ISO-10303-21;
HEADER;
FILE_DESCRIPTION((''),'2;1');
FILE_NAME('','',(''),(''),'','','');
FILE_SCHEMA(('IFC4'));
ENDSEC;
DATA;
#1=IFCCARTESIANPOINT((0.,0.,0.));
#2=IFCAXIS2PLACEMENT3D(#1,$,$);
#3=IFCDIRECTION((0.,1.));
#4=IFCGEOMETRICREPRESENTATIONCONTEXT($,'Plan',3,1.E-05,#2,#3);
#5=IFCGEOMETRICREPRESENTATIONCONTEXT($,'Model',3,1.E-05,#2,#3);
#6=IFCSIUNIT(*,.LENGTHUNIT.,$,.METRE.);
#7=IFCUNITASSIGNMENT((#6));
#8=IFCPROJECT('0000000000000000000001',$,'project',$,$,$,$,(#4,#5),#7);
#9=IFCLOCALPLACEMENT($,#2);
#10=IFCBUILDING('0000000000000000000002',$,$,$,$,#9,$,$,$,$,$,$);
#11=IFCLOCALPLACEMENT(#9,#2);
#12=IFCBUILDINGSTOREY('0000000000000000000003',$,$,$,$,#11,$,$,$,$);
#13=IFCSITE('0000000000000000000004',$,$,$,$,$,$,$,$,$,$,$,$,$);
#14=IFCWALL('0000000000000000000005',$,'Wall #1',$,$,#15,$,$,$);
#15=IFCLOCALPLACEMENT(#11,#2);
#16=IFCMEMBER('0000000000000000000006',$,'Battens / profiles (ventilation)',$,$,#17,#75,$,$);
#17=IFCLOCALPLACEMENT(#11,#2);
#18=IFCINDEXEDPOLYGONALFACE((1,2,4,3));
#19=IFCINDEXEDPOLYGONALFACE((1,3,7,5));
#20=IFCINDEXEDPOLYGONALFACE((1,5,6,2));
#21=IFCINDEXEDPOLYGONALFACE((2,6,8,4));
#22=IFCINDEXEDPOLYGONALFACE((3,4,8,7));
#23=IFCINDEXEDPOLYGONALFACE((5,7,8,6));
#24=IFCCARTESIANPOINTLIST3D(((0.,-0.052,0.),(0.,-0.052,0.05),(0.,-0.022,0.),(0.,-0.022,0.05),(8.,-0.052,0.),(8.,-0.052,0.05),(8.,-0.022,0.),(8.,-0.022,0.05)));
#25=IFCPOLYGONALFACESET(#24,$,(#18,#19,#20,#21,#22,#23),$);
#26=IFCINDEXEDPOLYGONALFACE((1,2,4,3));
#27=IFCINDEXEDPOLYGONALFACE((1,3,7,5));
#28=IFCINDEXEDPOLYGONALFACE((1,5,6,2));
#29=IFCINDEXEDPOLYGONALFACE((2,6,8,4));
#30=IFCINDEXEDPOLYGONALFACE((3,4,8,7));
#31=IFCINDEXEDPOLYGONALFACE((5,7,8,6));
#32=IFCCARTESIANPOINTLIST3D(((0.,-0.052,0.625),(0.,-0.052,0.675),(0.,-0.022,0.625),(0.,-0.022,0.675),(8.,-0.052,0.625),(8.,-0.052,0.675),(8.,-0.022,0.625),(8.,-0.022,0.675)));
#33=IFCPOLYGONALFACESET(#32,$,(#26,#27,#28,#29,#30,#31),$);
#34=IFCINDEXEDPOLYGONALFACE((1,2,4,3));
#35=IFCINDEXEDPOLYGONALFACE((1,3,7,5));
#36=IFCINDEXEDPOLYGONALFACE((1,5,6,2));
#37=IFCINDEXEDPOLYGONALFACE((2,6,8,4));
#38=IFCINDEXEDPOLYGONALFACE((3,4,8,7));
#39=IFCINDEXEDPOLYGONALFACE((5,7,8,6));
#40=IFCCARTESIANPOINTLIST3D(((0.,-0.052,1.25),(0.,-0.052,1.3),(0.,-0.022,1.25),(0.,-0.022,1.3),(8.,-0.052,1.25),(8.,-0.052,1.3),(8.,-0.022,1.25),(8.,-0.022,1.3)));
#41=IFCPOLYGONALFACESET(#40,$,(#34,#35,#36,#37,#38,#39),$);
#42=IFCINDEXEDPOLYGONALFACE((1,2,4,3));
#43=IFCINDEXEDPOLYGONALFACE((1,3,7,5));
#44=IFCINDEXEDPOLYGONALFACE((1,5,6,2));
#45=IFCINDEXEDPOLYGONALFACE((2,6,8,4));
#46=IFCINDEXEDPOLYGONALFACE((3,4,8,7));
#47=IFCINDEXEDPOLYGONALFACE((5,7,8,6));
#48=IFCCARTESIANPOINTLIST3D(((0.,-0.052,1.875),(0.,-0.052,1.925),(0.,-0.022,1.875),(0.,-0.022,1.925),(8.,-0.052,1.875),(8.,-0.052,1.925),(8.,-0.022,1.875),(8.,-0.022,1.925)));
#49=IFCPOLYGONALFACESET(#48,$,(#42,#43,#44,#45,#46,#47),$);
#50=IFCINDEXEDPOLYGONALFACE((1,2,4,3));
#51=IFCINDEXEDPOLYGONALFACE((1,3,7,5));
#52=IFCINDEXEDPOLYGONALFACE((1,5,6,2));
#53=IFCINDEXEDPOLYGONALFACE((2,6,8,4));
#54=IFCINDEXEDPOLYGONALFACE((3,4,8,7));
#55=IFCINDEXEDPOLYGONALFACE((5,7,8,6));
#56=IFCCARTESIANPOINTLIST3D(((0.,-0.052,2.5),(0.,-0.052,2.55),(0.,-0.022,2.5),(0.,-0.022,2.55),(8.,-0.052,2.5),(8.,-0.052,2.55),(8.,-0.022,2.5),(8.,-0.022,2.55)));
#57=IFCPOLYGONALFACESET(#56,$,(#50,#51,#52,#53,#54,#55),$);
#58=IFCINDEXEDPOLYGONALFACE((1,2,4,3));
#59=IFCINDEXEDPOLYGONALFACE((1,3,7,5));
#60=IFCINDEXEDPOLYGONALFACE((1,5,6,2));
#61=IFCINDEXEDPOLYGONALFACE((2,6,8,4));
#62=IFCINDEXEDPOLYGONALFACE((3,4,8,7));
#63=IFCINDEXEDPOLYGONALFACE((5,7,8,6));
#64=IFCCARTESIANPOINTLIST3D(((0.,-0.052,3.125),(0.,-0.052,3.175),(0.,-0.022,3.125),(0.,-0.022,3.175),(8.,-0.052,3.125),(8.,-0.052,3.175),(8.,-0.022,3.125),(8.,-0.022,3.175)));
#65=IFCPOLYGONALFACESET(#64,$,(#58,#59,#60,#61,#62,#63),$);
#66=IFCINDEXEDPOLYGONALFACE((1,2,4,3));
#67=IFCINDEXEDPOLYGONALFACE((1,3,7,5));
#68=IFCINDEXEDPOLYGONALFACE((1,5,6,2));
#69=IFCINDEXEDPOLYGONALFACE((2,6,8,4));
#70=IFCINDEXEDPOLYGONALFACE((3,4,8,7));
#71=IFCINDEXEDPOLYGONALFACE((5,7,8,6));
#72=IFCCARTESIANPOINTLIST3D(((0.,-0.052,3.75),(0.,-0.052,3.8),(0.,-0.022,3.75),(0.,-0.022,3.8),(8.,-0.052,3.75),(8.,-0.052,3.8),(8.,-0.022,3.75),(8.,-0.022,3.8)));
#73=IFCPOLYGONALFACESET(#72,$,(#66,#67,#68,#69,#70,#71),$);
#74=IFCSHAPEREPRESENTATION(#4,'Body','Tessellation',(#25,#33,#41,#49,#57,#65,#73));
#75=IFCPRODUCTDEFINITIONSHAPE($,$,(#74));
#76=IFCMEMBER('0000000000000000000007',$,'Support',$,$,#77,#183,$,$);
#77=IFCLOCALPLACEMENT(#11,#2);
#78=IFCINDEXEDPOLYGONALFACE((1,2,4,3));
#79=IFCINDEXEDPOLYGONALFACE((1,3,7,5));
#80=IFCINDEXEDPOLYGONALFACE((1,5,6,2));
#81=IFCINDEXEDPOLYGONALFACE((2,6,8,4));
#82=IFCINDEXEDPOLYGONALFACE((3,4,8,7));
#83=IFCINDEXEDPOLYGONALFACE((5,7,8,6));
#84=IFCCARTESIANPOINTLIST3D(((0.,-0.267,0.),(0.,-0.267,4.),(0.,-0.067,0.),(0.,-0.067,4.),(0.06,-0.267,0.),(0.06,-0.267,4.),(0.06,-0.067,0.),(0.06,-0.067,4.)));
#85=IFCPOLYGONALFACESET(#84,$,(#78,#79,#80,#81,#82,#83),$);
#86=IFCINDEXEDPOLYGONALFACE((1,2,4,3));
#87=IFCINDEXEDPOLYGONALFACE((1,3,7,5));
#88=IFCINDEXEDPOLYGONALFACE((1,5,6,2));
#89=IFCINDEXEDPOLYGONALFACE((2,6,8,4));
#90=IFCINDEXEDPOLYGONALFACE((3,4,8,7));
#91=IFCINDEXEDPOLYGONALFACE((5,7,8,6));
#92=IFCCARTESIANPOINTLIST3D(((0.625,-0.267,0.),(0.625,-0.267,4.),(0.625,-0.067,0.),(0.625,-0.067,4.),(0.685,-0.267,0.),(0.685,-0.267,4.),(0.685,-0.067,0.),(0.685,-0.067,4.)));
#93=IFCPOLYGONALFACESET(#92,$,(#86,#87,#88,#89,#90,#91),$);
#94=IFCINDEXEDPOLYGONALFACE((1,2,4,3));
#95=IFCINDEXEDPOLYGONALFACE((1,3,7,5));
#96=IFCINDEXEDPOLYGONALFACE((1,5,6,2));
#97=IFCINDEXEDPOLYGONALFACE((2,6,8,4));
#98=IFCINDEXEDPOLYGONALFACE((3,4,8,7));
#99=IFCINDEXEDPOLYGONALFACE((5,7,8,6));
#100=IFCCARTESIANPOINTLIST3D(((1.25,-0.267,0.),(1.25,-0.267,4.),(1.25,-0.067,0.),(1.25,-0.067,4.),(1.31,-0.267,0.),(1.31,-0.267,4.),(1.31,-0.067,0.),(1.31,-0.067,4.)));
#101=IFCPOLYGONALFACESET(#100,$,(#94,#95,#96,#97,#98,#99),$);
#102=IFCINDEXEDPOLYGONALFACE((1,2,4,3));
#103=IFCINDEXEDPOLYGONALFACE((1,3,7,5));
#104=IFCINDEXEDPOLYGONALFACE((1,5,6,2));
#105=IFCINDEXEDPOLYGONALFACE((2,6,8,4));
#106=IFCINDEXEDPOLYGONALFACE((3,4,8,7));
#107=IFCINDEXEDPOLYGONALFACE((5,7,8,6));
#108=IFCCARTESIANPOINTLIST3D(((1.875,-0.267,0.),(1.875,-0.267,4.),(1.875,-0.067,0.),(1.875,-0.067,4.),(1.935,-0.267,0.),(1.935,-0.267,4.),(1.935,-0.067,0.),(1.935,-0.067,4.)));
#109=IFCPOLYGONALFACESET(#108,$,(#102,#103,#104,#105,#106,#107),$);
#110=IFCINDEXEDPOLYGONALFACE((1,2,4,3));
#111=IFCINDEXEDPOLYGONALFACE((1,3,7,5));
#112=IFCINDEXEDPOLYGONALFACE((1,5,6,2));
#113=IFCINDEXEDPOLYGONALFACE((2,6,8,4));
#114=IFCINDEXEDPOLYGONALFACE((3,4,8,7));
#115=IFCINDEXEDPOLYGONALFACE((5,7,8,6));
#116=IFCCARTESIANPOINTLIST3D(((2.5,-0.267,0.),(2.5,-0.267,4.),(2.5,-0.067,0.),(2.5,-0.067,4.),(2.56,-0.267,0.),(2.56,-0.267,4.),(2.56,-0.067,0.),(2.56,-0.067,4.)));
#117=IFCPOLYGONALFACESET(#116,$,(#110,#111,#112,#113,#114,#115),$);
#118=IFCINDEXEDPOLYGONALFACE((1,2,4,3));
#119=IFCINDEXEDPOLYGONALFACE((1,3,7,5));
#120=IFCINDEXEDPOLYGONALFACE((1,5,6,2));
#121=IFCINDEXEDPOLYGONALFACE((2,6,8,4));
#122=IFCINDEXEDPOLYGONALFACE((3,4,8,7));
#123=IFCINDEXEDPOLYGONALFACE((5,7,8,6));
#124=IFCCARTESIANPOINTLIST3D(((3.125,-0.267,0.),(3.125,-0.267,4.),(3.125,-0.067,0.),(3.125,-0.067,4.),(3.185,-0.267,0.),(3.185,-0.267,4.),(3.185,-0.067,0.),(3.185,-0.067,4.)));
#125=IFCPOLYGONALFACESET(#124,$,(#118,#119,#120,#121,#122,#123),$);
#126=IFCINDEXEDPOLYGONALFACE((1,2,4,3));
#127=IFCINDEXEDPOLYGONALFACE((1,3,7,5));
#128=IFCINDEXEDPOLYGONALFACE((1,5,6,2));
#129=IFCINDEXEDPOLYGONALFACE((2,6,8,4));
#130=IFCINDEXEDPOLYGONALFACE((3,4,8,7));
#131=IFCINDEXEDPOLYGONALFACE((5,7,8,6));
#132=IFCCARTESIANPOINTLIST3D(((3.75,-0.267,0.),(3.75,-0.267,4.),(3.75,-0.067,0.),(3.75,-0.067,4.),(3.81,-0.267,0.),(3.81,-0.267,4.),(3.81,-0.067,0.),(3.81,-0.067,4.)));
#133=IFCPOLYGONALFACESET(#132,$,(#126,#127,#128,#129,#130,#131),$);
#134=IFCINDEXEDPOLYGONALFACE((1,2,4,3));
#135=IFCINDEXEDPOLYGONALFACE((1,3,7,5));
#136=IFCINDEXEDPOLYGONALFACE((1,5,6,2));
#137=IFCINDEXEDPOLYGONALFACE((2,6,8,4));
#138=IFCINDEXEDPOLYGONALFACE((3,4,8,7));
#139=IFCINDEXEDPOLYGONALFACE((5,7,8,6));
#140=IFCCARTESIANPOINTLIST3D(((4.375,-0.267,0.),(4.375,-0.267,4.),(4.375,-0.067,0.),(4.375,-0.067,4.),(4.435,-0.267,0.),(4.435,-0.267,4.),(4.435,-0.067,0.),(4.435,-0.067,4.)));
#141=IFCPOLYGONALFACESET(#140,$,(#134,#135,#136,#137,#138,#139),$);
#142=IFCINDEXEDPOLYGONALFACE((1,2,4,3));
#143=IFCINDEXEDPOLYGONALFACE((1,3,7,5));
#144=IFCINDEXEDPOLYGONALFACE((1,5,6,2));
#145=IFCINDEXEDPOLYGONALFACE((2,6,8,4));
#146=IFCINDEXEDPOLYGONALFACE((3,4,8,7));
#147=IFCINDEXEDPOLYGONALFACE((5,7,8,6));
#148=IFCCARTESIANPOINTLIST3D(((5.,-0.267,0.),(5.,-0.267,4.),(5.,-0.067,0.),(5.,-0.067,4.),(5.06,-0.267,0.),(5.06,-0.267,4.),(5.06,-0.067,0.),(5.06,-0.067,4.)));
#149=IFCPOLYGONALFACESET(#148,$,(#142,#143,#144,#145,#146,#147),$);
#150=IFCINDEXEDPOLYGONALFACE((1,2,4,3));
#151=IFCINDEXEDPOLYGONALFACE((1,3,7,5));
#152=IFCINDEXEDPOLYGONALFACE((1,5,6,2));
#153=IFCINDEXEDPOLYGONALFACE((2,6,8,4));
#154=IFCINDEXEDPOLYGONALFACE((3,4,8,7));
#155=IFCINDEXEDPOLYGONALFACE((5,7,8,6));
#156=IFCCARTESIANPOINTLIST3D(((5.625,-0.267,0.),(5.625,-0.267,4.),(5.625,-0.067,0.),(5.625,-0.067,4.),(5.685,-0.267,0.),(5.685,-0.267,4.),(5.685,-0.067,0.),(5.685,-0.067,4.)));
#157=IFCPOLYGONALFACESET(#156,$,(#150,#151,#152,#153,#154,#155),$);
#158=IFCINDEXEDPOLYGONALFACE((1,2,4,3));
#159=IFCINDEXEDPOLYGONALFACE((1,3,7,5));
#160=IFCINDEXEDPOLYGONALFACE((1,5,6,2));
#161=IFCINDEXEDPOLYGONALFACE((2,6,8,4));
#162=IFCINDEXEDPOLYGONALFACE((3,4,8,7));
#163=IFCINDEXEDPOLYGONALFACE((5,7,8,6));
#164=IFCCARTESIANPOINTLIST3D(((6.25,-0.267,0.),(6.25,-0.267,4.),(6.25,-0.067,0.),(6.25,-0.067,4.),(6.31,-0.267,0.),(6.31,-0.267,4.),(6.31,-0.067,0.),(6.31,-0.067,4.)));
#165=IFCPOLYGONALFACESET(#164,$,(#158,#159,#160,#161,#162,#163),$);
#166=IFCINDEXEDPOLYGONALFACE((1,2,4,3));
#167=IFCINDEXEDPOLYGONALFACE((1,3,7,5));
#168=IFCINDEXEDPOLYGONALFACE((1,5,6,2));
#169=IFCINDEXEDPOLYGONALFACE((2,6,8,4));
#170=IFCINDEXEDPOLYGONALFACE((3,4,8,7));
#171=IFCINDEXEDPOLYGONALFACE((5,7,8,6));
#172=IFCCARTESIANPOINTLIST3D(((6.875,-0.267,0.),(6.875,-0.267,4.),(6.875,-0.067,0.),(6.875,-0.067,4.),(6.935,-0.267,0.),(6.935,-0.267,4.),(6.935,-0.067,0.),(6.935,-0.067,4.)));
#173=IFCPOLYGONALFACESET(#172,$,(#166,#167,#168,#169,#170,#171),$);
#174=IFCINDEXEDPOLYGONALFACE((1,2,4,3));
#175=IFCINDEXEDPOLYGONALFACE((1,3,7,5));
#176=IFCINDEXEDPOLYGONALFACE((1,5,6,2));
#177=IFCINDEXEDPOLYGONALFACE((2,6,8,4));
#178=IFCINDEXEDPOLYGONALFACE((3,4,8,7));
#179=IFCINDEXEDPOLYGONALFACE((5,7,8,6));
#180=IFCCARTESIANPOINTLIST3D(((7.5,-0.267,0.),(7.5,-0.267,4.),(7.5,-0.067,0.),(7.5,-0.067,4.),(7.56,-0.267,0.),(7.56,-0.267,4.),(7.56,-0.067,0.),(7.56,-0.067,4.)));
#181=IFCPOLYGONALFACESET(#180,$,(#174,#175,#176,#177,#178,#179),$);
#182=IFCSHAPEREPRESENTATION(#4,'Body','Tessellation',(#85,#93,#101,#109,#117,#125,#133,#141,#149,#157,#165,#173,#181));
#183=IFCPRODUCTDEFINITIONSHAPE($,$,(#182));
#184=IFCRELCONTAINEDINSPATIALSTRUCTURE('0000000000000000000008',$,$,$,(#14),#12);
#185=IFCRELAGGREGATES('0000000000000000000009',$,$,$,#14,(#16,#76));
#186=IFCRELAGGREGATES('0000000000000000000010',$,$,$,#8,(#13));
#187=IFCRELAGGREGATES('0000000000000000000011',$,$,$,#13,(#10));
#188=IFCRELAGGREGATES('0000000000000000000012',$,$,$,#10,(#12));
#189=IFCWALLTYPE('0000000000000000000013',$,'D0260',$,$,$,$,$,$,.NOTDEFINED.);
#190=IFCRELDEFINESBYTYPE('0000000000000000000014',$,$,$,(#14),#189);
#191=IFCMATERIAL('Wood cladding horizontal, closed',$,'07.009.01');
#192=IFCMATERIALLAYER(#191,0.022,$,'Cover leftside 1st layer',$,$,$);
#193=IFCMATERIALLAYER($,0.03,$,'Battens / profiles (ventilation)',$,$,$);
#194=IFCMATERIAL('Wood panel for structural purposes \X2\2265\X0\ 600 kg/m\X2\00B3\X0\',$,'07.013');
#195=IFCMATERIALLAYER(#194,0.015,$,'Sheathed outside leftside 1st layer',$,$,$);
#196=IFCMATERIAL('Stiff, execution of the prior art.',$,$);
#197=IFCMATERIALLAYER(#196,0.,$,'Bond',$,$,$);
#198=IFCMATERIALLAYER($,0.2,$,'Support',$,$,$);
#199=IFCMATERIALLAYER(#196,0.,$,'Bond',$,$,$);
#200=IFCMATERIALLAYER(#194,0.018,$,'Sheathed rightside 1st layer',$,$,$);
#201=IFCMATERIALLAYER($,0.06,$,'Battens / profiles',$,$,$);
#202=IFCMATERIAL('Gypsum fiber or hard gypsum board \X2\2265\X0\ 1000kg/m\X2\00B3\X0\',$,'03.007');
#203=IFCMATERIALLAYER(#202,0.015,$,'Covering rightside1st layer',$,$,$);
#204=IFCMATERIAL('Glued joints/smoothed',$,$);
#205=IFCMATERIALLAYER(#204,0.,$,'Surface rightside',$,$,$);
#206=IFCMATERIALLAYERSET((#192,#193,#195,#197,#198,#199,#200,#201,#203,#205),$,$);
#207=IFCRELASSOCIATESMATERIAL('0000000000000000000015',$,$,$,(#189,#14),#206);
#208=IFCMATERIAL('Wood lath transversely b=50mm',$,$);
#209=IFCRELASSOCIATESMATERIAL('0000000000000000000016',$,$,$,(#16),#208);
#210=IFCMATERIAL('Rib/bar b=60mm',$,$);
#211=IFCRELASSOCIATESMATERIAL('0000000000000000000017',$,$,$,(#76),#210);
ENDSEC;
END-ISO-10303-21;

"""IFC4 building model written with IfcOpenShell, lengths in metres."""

from ifc_helpers import new_model, si_unit, direction, frame, frame_2d, origin, place, context, project, spatial, rectangle, extrude, material, layer, layer_set, type_object, element, aggregate, save


model = new_model("IFC4")

# Units and contexts
plan_context = context("Plan", 3, precision=1e-05, world=origin(), true_north=direction((0.0, 1.0)))
model_context = context("Model", 3, precision=1e-05, world=origin(), true_north=direction((0.0, 1.0)))
ifc_project = project(units=[si_unit("LENGTHUNIT", "METRE")], contexts=[plan_context, model_context])

# Site, building, storey
site = spatial("IfcSite", under=ifc_project)
building_placement = place(None, origin())
building = spatial("IfcBuilding", under=site, at=building_placement)
storey_placement = place(building_placement, origin())
storey = spatial("IfcBuildingStorey", under=building, at=storey_placement)

# Wall, members
ifc_material_1 = material(Name="Wood cladding horizontal, closed", Category="07.009.01")
ifc_layer_1 = layer(ifc_material_1, 0.022, Name="Cover leftside 1st layer")
ifc_layer_2 = layer(None, 0.03, Name="Battens / profiles (ventilation)")
ifc_material_2 = material(Name="Wood panel for structural purposes ≥ 600 kg/m³", Category="07.013")
ifc_layer_3 = layer(ifc_material_2, 0.015, Name="Sheathed outside leftside 1st layer")
ifc_material_3 = material(Name="Stiff, execution of the prior art.")
ifc_layer_4 = layer(ifc_material_3, 0.0, Name="Bond")
ifc_layer_5 = layer(None, 0.2, Name="Support")
ifc_layer_6 = layer(ifc_material_3, 0.0, Name="Bond")
ifc_layer_7 = layer(ifc_material_2, 0.018, Name="Sheathed rightside 1st layer")
ifc_layer_8 = layer(None, 0.06, Name="Battens / profiles")
ifc_material_4 = material(Name="Gypsum fiber or hard gypsum board ≥ 1000kg/m³", Category="03.007")
ifc_layer_9 = layer(ifc_material_4, 0.015, Name="Covering rightside1st layer")
ifc_material_5 = material(Name="Glued joints/smoothed")
ifc_layer_10 = layer(ifc_material_5, 0.0, Name="Surface rightside")
ifc_layer_set = layer_set([ifc_layer_1, ifc_layer_2, ifc_layer_3, ifc_layer_4, ifc_layer_5, ifc_layer_6, ifc_layer_7, ifc_layer_8, ifc_layer_9, ifc_layer_10])
wall_type = type_object("IfcWallType", Name="D0260", PredefinedType="NOTDEFINED", material=ifc_layer_set)
wall_placement = place(None, frame((0.0, 0.0, 0.0), z_axis=(0.0, -1.0, 0.0), x_axis=(1.0, 0.0, 0.0)))
wall = element("IfcWall", 1, at=wall_placement, inside=storey, type_object=wall_type, material=ifc_layer_set, Name="Wall #1")
ifc_material_6 = material(Name="Wood lath transversely b=50mm")
member_1_placement = place(wall_placement, origin())
member_1 = element("IfcMember", 2, at=member_1_placement, material=ifc_material_6, Name="Battens / profiles (ventilation)", context=plan_context, shape_type="SweptSolid", body=[
    extrude(rectangle(XDim=0.05, YDim=0.03, at=frame_2d((0.025, 0.015), x_axis=(1.0, 0.0))), frame((0.0, 0.0, 0.022), z_axis=(1.0, 0.0, 0.0), x_axis=(0.0, 1.0, 0.0)), (0.0, 0.0, 1.0), 8.0),
    extrude(rectangle(XDim=0.05, YDim=0.03, at=frame_2d((0.025, 0.015), x_axis=(1.0, 0.0))), frame((0.0, 0.625, 0.022), z_axis=(1.0, 0.0, 0.0), x_axis=(0.0, 1.0, 0.0)), (0.0, 0.0, 1.0), 8.0),
    extrude(rectangle(XDim=0.05, YDim=0.03, at=frame_2d((0.025, 0.015), x_axis=(1.0, 0.0))), frame((0.0, 1.25, 0.022), z_axis=(1.0, 0.0, 0.0), x_axis=(0.0, 1.0, 0.0)), (0.0, 0.0, 1.0), 8.0),
    extrude(rectangle(XDim=0.05, YDim=0.03, at=frame_2d((0.025, 0.015), x_axis=(1.0, 0.0))), frame((0.0, 1.875, 0.022), z_axis=(1.0, 0.0, 0.0), x_axis=(0.0, 1.0, 0.0)), (0.0, 0.0, 1.0), 8.0),
    extrude(rectangle(XDim=0.05, YDim=0.03, at=frame_2d((0.025, 0.015), x_axis=(1.0, 0.0))), frame((0.0, 2.5, 0.022), z_axis=(1.0, 0.0, 0.0), x_axis=(0.0, 1.0, 0.0)), (0.0, 0.0, 1.0), 8.0),
    extrude(rectangle(XDim=0.05, YDim=0.03, at=frame_2d((0.025, 0.015), x_axis=(1.0, 0.0))), frame((0.0, 3.125, 0.022), z_axis=(1.0, 0.0, 0.0), x_axis=(0.0, 1.0, 0.0)), (0.0, 0.0, 1.0), 8.0),
    extrude(rectangle(XDim=0.05, YDim=0.03, at=frame_2d((0.025, 0.015), x_axis=(1.0, 0.0))), frame((0.0, 3.75, 0.022), z_axis=(1.0, 0.0, 0.0), x_axis=(0.0, 1.0, 0.0)), (0.0, 0.0, 1.0), 8.0),
])
ifc_material_7 = material(Name="Rib/bar b=60mm")
member_2_placement = place(wall_placement, origin())
member_2 = element("IfcMember", 3, at=member_2_placement, material=ifc_material_7, Name="Support", context=plan_context, shape_type="SweptSolid", body=[
    extrude(rectangle(XDim=0.06, YDim=0.2, at=frame_2d((0.03, 0.1), x_axis=(1.0, 0.0))), frame((0.0, 4.0, 0.067), z_axis=(0.0, -1.0, 0.0), x_axis=(1.0, 0.0, 0.0)), (0.0, 0.0, 1.0), 4.0),
    extrude(rectangle(XDim=0.06, YDim=0.2, at=frame_2d((0.03, 0.1), x_axis=(1.0, 0.0))), frame((0.625, 4.0, 0.067), z_axis=(0.0, -1.0, 0.0), x_axis=(1.0, 0.0, 0.0)), (0.0, 0.0, 1.0), 4.0),
    extrude(rectangle(XDim=0.06, YDim=0.2, at=frame_2d((0.03, 0.1), x_axis=(1.0, 0.0))), frame((1.25, 4.0, 0.067), z_axis=(0.0, -1.0, 0.0), x_axis=(1.0, 0.0, 0.0)), (0.0, 0.0, 1.0), 4.0),
    extrude(rectangle(XDim=0.06, YDim=0.2, at=frame_2d((0.03, 0.1), x_axis=(1.0, 0.0))), frame((1.875, 4.0, 0.067), z_axis=(0.0, -1.0, 0.0), x_axis=(1.0, 0.0, 0.0)), (0.0, 0.0, 1.0), 4.0),
    extrude(rectangle(XDim=0.06, YDim=0.2, at=frame_2d((0.03, 0.1), x_axis=(1.0, 0.0))), frame((2.5, 4.0, 0.067), z_axis=(0.0, -1.0, 0.0), x_axis=(1.0, 0.0, 0.0)), (0.0, 0.0, 1.0), 4.0),
    extrude(rectangle(XDim=0.06, YDim=0.2, at=frame_2d((0.03, 0.1), x_axis=(1.0, 0.0))), frame((3.125, 4.0, 0.067), z_axis=(0.0, -1.0, 0.0), x_axis=(1.0, 0.0, 0.0)), (0.0, 0.0, 1.0), 4.0),
    extrude(rectangle(XDim=0.06, YDim=0.2, at=frame_2d((0.03, 0.1), x_axis=(1.0, 0.0))), frame((3.75, 4.0, 0.067), z_axis=(0.0, -1.0, 0.0), x_axis=(1.0, 0.0, 0.0)), (0.0, 0.0, 1.0), 4.0),
    extrude(rectangle(XDim=0.06, YDim=0.2, at=frame_2d((0.03, 0.1), x_axis=(1.0, 0.0))), frame((4.375, 4.0, 0.067), z_axis=(0.0, -1.0, 0.0), x_axis=(1.0, 0.0, 0.0)), (0.0, 0.0, 1.0), 4.0),
    extrude(rectangle(XDim=0.06, YDim=0.2, at=frame_2d((0.03, 0.1), x_axis=(1.0, 0.0))), frame((5.0, 4.0, 0.067), z_axis=(0.0, -1.0, 0.0), x_axis=(1.0, 0.0, 0.0)), (0.0, 0.0, 1.0), 4.0),
    extrude(rectangle(XDim=0.06, YDim=0.2, at=frame_2d((0.03, 0.1), x_axis=(1.0, 0.0))), frame((5.625, 4.0, 0.067), z_axis=(0.0, -1.0, 0.0), x_axis=(1.0, 0.0, 0.0)), (0.0, 0.0, 1.0), 4.0),
    extrude(rectangle(XDim=0.06, YDim=0.2, at=frame_2d((0.03, 0.1), x_axis=(1.0, 0.0))), frame((6.25, 4.0, 0.067), z_axis=(0.0, -1.0, 0.0), x_axis=(1.0, 0.0, 0.0)), (0.0, 0.0, 1.0), 4.0),
    extrude(rectangle(XDim=0.06, YDim=0.2, at=frame_2d((0.03, 0.1), x_axis=(1.0, 0.0))), frame((6.875, 4.0, 0.067), z_axis=(0.0, -1.0, 0.0), x_axis=(1.0, 0.0, 0.0)), (0.0, 0.0, 1.0), 4.0),
    extrude(rectangle(XDim=0.06, YDim=0.2, at=frame_2d((0.03, 0.1), x_axis=(1.0, 0.0))), frame((7.5, 4.0, 0.067), z_axis=(0.0, -1.0, 0.0), x_axis=(1.0, 0.0, 0.0)), (0.0, 0.0, 1.0), 4.0),
])
aggregate(wall, [member_1, member_2])

save(model, "model.ifc")
